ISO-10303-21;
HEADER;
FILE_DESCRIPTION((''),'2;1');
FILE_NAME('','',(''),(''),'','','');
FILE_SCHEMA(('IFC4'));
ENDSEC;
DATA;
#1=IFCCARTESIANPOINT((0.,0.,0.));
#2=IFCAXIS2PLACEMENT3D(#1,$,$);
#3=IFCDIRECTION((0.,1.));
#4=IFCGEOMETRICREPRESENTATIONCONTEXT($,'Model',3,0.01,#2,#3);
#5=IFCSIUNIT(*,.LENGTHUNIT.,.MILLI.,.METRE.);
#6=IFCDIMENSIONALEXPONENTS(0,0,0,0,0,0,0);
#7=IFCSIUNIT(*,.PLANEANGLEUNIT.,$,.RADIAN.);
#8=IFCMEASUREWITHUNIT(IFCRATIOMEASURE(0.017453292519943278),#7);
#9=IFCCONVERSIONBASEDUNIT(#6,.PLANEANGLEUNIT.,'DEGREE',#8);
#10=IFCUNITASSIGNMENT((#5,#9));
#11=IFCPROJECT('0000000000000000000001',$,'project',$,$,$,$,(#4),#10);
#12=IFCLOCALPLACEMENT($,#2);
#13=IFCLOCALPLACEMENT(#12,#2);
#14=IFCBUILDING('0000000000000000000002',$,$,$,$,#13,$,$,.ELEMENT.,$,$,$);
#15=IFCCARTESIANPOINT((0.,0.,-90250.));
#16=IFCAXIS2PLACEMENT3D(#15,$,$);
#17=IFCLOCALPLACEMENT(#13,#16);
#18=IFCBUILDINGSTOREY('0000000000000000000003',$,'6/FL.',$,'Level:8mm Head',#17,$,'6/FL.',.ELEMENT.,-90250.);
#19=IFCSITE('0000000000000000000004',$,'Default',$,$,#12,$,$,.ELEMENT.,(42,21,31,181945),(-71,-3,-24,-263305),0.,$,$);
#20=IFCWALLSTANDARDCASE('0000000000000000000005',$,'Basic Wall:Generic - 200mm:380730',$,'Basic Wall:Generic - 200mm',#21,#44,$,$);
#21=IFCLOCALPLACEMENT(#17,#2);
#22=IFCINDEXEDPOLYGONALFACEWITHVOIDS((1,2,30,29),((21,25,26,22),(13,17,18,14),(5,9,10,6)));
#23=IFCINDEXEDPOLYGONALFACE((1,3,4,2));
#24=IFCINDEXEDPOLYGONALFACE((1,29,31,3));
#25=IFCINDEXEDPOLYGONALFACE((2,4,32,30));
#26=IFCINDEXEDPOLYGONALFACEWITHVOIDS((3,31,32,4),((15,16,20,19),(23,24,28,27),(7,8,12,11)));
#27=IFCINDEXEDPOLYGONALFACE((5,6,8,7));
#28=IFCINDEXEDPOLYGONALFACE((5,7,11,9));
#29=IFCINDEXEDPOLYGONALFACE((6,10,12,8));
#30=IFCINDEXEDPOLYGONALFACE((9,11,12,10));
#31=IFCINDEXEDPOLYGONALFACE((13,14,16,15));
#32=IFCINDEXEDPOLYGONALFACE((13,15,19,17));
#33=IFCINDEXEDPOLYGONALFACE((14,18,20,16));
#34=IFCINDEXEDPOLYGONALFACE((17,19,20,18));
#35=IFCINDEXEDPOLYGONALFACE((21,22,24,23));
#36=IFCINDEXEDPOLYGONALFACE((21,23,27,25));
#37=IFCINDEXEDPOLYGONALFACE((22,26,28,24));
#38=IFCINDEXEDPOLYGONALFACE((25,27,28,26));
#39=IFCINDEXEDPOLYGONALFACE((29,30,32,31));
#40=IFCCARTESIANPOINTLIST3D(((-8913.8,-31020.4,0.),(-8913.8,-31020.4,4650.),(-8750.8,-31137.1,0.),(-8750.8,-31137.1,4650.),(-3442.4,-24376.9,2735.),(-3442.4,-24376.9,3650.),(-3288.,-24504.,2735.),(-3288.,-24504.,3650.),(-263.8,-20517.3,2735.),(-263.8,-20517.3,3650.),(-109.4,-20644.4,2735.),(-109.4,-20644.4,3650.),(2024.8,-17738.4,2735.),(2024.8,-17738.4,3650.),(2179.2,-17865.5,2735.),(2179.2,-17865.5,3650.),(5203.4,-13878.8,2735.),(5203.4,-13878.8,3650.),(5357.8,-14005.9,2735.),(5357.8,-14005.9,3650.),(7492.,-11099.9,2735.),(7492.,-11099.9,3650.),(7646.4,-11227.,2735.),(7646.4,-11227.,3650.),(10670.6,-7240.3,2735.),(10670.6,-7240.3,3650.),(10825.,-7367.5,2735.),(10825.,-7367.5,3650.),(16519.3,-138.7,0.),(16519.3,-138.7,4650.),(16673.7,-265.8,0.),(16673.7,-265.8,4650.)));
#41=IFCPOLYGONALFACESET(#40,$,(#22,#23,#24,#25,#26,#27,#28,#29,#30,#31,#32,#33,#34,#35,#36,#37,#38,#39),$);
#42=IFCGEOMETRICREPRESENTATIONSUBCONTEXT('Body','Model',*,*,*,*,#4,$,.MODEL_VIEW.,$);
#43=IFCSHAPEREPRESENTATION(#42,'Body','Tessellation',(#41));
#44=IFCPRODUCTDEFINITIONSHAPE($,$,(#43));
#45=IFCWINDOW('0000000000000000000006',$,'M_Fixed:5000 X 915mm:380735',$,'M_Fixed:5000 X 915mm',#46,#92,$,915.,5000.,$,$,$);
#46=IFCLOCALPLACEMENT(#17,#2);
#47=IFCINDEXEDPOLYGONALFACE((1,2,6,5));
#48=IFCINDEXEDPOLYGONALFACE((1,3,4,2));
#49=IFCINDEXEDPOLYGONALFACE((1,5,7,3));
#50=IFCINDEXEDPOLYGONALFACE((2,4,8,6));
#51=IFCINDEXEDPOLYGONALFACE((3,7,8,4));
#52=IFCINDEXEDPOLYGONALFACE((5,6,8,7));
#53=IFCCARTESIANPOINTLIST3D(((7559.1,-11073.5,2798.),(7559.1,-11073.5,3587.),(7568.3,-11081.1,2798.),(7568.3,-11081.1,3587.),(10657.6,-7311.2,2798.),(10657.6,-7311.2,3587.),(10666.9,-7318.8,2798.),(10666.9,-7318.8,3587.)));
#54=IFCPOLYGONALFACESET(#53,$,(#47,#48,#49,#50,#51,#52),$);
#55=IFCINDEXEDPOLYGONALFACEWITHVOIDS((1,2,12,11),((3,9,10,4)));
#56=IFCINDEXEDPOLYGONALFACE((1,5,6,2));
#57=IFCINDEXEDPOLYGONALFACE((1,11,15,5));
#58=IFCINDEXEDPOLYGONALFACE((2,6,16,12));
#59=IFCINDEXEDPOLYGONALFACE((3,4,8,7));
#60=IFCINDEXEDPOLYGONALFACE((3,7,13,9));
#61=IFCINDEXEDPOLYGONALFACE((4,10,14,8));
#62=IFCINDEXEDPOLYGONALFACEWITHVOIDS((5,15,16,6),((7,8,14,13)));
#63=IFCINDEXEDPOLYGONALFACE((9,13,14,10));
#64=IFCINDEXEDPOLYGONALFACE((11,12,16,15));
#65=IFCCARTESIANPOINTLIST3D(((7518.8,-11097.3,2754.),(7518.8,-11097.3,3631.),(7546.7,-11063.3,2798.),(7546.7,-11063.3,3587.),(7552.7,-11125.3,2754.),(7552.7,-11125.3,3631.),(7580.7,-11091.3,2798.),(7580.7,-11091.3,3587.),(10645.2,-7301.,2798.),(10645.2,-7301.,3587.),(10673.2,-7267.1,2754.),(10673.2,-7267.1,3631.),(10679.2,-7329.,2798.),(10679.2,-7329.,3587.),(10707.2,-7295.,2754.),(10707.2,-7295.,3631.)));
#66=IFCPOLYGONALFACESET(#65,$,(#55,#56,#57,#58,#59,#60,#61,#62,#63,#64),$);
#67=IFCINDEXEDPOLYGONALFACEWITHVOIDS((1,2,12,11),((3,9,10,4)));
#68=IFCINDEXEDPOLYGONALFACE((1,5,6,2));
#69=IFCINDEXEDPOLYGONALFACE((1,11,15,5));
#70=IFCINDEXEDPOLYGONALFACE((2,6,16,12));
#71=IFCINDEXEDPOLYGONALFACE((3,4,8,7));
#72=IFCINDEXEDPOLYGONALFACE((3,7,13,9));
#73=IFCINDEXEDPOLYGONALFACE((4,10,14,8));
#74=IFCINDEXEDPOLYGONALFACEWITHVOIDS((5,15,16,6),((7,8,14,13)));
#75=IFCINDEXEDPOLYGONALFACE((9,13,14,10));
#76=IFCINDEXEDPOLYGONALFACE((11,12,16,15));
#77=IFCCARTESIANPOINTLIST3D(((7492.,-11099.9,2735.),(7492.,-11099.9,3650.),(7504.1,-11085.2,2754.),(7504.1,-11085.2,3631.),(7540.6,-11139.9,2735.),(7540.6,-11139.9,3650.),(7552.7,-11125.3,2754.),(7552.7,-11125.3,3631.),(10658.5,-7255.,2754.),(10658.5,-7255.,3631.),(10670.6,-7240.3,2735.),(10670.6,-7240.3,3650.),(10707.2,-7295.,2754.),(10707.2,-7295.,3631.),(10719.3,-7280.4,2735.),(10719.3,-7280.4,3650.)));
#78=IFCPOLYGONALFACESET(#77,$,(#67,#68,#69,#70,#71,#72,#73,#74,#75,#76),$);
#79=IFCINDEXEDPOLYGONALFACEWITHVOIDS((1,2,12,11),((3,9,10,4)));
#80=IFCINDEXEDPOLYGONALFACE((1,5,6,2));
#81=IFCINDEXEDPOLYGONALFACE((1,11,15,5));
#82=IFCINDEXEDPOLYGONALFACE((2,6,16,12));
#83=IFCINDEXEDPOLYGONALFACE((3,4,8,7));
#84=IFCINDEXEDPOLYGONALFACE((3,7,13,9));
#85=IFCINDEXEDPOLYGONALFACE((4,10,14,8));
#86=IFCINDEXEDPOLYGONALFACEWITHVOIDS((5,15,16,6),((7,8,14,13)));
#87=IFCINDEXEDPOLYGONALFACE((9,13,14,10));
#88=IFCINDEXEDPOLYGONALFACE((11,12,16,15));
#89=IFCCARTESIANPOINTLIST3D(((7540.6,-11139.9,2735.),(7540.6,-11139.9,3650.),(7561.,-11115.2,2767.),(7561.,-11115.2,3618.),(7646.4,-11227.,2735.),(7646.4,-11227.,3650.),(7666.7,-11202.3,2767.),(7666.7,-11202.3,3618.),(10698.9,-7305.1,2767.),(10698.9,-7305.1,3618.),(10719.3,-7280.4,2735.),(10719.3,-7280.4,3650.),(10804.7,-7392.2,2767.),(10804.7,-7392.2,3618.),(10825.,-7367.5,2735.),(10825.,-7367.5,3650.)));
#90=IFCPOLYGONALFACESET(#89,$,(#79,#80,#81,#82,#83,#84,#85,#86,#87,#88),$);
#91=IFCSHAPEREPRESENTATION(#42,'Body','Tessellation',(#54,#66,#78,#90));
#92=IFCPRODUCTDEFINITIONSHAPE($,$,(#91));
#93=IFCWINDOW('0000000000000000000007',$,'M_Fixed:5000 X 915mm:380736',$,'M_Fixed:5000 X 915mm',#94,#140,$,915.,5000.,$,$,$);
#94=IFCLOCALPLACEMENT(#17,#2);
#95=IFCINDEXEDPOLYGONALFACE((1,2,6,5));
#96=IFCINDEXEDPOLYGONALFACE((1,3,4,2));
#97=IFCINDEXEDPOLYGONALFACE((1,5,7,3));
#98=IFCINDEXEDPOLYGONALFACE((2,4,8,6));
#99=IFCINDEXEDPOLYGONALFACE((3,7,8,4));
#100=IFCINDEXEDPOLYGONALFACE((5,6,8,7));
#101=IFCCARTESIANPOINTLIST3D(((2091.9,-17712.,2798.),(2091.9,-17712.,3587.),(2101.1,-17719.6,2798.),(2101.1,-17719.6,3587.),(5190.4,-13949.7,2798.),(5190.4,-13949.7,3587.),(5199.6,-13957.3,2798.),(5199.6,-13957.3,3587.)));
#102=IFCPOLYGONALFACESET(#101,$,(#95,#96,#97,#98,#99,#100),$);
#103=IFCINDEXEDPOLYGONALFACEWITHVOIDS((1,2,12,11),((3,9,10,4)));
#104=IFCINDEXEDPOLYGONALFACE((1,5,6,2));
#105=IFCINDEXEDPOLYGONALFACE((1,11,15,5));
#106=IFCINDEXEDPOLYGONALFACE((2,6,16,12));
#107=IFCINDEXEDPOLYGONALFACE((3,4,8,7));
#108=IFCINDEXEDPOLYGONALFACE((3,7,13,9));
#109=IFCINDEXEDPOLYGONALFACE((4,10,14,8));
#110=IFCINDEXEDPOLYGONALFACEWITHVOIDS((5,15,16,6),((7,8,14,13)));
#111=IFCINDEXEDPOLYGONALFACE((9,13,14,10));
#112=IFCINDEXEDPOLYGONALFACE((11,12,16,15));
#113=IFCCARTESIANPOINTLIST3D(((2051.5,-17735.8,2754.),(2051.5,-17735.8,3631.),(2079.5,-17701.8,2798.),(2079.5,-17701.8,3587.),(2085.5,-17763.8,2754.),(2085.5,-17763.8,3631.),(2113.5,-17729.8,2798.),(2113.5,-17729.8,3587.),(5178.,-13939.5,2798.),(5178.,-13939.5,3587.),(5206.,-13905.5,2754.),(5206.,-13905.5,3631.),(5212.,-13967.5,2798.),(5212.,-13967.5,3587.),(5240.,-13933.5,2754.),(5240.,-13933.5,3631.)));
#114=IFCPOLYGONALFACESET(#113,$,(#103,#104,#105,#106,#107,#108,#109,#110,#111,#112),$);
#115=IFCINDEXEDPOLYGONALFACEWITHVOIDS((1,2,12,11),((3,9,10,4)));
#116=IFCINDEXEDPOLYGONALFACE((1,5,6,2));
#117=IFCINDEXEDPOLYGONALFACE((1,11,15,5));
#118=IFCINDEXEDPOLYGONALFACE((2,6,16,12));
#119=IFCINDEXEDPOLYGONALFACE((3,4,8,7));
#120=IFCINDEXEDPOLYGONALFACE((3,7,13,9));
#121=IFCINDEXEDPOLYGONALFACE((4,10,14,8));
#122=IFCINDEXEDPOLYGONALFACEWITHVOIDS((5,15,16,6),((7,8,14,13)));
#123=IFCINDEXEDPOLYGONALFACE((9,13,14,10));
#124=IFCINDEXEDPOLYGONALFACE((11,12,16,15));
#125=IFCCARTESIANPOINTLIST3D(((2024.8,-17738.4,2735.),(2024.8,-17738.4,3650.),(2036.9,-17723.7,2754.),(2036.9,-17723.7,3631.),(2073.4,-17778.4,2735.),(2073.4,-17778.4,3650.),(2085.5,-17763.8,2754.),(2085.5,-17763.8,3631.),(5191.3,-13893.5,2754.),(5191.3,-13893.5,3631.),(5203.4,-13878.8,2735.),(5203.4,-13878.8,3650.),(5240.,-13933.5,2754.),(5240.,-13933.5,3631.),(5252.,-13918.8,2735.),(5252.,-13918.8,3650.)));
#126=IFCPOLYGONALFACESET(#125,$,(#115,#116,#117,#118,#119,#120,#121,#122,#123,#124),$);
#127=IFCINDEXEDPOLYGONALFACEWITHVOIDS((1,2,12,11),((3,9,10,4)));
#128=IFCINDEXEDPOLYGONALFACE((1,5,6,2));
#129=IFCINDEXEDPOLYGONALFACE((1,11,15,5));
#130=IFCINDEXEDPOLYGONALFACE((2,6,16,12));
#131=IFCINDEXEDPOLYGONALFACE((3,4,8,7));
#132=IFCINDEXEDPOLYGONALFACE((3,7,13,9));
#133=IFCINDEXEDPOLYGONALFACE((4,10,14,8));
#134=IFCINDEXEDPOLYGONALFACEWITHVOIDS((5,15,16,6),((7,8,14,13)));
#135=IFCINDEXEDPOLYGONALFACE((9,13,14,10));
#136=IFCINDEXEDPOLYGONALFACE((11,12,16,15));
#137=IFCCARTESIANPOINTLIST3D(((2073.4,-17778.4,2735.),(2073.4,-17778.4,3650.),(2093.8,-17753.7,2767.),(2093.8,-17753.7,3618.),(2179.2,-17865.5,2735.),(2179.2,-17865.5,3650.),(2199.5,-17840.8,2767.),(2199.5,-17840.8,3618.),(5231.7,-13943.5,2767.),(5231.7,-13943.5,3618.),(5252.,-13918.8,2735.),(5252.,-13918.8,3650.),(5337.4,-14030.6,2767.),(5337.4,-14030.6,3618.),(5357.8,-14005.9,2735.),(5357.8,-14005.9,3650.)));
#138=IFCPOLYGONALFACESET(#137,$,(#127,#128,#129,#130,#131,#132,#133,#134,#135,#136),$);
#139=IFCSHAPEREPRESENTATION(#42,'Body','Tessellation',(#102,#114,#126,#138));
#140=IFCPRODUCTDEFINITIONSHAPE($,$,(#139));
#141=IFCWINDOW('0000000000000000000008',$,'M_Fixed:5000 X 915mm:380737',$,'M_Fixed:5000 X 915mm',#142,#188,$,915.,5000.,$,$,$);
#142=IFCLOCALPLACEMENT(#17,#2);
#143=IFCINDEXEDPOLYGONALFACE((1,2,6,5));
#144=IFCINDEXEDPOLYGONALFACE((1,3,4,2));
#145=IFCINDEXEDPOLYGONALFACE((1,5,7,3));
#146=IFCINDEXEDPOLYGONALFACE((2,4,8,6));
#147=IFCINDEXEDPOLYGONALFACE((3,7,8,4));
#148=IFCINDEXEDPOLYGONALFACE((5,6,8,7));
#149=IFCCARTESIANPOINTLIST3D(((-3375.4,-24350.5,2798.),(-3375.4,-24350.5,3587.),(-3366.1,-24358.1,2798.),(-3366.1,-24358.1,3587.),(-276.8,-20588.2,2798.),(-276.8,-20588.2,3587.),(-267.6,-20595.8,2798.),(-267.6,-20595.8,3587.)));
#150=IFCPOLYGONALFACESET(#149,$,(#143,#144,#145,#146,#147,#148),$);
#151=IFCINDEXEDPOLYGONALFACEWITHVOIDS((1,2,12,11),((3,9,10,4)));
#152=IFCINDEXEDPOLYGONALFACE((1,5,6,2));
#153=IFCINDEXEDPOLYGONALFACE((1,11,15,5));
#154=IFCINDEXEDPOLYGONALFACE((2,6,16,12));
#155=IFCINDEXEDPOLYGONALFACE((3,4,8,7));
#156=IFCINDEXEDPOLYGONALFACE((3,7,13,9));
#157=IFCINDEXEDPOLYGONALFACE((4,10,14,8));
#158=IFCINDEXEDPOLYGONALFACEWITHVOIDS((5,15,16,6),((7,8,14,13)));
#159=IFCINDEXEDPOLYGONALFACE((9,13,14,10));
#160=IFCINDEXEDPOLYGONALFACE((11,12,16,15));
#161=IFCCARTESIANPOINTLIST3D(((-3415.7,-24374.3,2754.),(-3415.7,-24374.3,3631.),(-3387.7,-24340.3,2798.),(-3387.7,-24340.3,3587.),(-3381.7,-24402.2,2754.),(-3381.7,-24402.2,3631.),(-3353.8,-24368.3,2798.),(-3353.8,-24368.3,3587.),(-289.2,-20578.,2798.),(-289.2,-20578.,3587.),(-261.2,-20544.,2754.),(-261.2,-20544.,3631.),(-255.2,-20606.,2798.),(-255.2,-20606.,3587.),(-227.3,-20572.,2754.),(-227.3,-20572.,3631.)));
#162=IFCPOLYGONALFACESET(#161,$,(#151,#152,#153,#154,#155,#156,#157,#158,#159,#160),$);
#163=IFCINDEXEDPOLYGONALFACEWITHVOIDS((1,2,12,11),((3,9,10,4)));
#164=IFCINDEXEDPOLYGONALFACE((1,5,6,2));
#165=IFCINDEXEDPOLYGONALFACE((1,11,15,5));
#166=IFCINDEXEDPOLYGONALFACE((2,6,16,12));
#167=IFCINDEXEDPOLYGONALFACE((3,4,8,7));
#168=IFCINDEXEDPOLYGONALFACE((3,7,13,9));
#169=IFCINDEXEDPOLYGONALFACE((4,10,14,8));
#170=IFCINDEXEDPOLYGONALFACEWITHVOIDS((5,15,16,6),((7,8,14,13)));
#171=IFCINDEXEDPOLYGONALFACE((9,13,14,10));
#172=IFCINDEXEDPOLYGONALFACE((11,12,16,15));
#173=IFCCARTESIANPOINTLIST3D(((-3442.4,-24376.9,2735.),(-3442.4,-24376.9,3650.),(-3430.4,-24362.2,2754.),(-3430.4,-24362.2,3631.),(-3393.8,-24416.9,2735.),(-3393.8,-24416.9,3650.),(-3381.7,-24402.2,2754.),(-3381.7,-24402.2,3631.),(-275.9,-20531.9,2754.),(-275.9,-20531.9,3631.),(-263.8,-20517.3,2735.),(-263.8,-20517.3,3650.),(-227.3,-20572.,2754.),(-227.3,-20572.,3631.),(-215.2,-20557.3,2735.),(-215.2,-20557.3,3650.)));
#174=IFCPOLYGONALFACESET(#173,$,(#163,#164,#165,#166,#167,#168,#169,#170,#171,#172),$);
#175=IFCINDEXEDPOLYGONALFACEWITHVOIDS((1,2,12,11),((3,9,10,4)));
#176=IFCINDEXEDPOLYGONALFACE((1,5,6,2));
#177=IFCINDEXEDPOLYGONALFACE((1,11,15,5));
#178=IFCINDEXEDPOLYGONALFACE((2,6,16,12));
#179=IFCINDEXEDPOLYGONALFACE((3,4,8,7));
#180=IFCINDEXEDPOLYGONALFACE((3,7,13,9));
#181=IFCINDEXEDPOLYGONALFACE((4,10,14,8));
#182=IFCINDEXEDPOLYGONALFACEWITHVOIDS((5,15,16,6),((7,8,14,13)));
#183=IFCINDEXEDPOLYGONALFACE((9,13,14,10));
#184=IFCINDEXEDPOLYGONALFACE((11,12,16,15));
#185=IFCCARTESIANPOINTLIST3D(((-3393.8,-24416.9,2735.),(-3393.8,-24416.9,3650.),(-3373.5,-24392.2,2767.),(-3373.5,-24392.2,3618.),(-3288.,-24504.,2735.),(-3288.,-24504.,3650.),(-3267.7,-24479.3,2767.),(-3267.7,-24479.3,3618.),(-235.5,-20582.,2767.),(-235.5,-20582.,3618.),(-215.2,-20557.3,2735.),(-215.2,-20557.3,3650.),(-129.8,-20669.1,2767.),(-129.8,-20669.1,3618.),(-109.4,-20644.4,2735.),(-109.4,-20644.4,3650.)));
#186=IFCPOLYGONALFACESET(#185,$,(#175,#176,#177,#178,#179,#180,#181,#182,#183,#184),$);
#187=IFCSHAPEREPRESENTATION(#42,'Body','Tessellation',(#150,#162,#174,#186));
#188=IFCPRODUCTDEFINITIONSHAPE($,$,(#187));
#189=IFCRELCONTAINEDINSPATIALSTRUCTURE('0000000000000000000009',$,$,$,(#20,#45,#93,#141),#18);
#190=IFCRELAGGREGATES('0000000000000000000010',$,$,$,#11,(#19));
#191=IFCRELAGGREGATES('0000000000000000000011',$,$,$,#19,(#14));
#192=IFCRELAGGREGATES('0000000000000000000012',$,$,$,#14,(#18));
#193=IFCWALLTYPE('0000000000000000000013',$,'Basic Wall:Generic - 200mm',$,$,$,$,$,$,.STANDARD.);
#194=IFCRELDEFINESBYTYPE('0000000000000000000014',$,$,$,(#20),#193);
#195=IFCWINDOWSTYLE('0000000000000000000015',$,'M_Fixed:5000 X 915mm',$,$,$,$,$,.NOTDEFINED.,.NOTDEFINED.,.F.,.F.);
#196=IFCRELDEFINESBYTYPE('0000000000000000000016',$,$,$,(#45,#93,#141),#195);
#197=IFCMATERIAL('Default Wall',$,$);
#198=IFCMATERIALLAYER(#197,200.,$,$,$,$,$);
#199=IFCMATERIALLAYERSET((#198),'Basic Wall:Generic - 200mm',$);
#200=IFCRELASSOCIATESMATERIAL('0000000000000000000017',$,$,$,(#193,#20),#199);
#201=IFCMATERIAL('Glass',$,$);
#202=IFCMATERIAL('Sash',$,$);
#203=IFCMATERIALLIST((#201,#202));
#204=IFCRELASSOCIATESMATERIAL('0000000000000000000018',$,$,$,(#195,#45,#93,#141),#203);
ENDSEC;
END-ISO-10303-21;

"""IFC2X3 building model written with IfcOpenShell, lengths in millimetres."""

from ifc_helpers import new_model, entity, si_unit, converted_unit, direction, frame, frame_2d, origin, place, context, subcontext, project, spatial, polyline, rectangle, outline, extrude, source, transform, mapped, material, material_list, layer, layer_set, layer_usage, type_object, type_shapes, element, fill, save


model = new_model("IFC2X3")

# Units and contexts
model_context = context("Model", 3, precision=0.01, world=origin(), true_north=direction((0.0, 1.0)))
body_context = subcontext(model_context, "Body", "Model", "MODEL_VIEW")
ifc_project = project(units=[si_unit("LENGTHUNIT", "METRE", prefix="MILLI"), converted_unit("PLANEANGLEUNIT", "DEGREE", entity("IfcRatioMeasure", 0.017453292519943278), si_unit("PLANEANGLEUNIT", "RADIAN"), dimensions=[0, 0, 0, 0, 0, 0, 0])], contexts=[model_context])

# Site, building, storey
site_placement = place(None, origin())
site = spatial("IfcSite", under=ifc_project, at=site_placement, Name="Default", CompositionType="ELEMENT", RefLatitude=(42, 21, 31, 181945), RefLongitude=(-71, -3, -24, -263305), RefElevation=0.0)
building_placement = place(site_placement, origin())
building = spatial("IfcBuilding", under=site, at=building_placement, CompositionType="ELEMENT")
storey_placement = place(building_placement, frame((0.0, 0.0, -90250.0)))
storey = spatial("IfcBuildingStorey", under=building, at=storey_placement, Name="6/FL.", ObjectType="Level:8mm Head", LongName="6/FL.", CompositionType="ELEMENT", Elevation=-90250.0)

# Shared definitions
ifc_material_1 = material(Name="Default Wall")
ifc_layer = layer(ifc_material_1, 200.0)
ifc_layer_set = layer_set([ifc_layer], Name="Basic Wall:Generic - 200mm")
ifc_layer_usage = layer_usage(ifc_layer_set, "AXIS2", "NEGATIVE", 100.0)
wall_type = type_object("IfcWallType", Name="Basic Wall:Generic - 200mm", PredefinedType="STANDARD", material=ifc_layer_set)

# Wall, openings, windows
wall_1_placement = place(storey_placement, frame((17105.1, 415.3, 0.0), z_axis=(0.0, 0.0, 1.0), x_axis=(-0.635723, -0.771917, 0.0)))
wall_1 = element("IfcWallStandardCase", 1, at=wall_1_placement, inside=storey, type_object=wall_type, material=ifc_layer_usage, Name="Basic Wall:Generic - 200mm:380730", ObjectType="Basic Wall:Generic - 200mm", context=body_context, shape_type="SweptSolid", body=[
    extrude(outline(polyline([(40806.5, -100.0), (40793.0, 100.0), (37219.3, 100.0), (37019.3, 100.0), (800.0, 100.0), (800.0, -100.0), (37019.3, -100.0), (37219.3, -100.0), (40806.5, -100.0)])), origin(), (0.0, 0.0, 1.0), 4650.0),
])
opening_1_placement = place(wall_1_placement, origin())
element("IfcOpeningElement", 2, at=opening_1_placement, cuts=wall_1, ObjectType="Opening", context=body_context, shape_type="SweptSolid", body=[
    extrude(rectangle(XDim=1000.0, YDim=1012.7, at=frame_2d((0.0, 0.0), x_axis=(1.0, 0.0))), frame((293.7, -183.3, 500.0), z_axis=(0.0, 1.0, 0.0), x_axis=(0.0, 0.0, -1.0)), (0.0, 0.0, 1.0), 1010.1),
])
opening_2_placement = place(wall_1_placement, frame((15000.0, 100.0, 2735.0)))
opening_2 = element("IfcOpeningElement", 3, at=opening_2_placement, cuts=wall_1, ObjectType="Opening", context=body_context, shape_type="SweptSolid", body=[
    extrude(rectangle(XDim=915.0, YDim=5000.0, at=frame_2d((457.5, 2500.0), x_axis=(1.0, 0.0))), frame((0.0, 0.0, 0.0), z_axis=(0.0, -1.0, 0.0), x_axis=(0.0, 0.0, 1.0)), (0.0, 0.0, 1.0), 200.0),
])
opening_3_placement = place(wall_1_placement, frame((23600.0, 100.0, 2735.0)))
opening_3 = element("IfcOpeningElement", 4, at=opening_3_placement, cuts=wall_1, ObjectType="Opening", context=body_context, shape_type="SweptSolid", body=[
    extrude(rectangle(XDim=915.0, YDim=5000.0, at=frame_2d((457.5, 2500.0), x_axis=(1.0, 0.0))), frame((0.0, 0.0, 0.0), z_axis=(0.0, -1.0, 0.0), x_axis=(0.0, 0.0, 1.0)), (0.0, 0.0, 1.0), 200.0),
])
opening_4_placement = place(wall_1_placement, frame((32200.0, 100.0, 2735.0)))
opening_4 = element("IfcOpeningElement", 5, at=opening_4_placement, cuts=wall_1, ObjectType="Opening", context=body_context, shape_type="SweptSolid", body=[
    extrude(rectangle(XDim=915.0, YDim=5000.0, at=frame_2d((457.5, 2500.0), x_axis=(1.0, 0.0))), frame((0.0, 0.0, 0.0), z_axis=(0.0, -1.0, 0.0), x_axis=(0.0, 0.0, 1.0)), (0.0, 0.0, 1.0), 200.0),
])
ifc_material_2 = material(Name="Glass")
ifc_material_3 = material(Name="Sash")
ifc_material_list = material_list([ifc_material_2, ifc_material_3])
window_style_1 = type_object("IfcWindowStyle", Name="M_Fixed:5000 X 915mm", ConstructionType="NOTDEFINED", OperationType="NOTDEFINED", ParameterTakesPrecedence=False, Sizeable=False, material=ifc_material_list)
shared_shape_1 = source(origin(), body_context, "Body", "SweptSolid", [
    extrude(rectangle(XDim=12.0, YDim=4874.0, at=frame_2d((0.0, 0.0), x_axis=(1.0, 0.0))), frame((2500.0, 159.0, 63.0), z_axis=(0.0, 0.0, 1.0), x_axis=(0.0, -1.0, 0.0)), (0.0, 0.0, 1.0), 789.0),
    extrude(outline(polyline([(-2481.0, -438.5), (2481.0, -438.5), (2481.0, 438.5), (-2481.0, 438.5), (-2481.0, -438.5)]), holes=[polyline([(-2437.0, -394.5), (-2437.0, 394.5), (2437.0, 394.5), (2437.0, -394.5), (-2437.0, -394.5)])]), frame((2500.0, 137.0, 457.5), z_axis=(0.0, 1.0, 0.0), x_axis=(1.0, 0.0, 0.0)), (0.0, 0.0, 1.0), 44.0),
    extrude(outline(polyline([(-2500.0, -457.5), (2500.0, -457.5), (2500.0, 457.5), (-2500.0, 457.5), (-2500.0, -457.5)]), holes=[polyline([(-2481.0, -438.5), (-2481.0, 438.5), (2481.0, 438.5), (2481.0, -438.5), (-2481.0, -438.5)])]), frame((2500.0, 137.0, 457.5), z_axis=(0.0, 1.0, 0.0), x_axis=(1.0, 0.0, 0.0)), (0.0, 0.0, 1.0), 63.0),
    extrude(outline(polyline([(-2500.0, -457.5), (2500.0, -457.5), (2500.0, 457.5), (-2500.0, 457.5), (-2500.0, -457.5)]), holes=[polyline([(-2468.0, -425.5), (-2468.0, 425.5), (2468.0, 425.5), (2468.0, -425.5), (-2468.0, -425.5)])]), frame((2500.0, 0.0, 457.5), z_axis=(0.0, 1.0, 0.0), x_axis=(1.0, 0.0, 0.0)), (0.0, 0.0, 1.0), 137.0),
])
type_shapes(window_style_1, [shared_shape_1])
window_1_placement = place(opening_2_placement, frame((0.0, 0.0, 0.0), z_axis=(0.0, 0.0, 1.0), x_axis=(-1.0, 0.0, 0.0)))
window_1 = element("IfcWindow", 6, at=window_1_placement, inside=storey, type_object=window_style_1, material=ifc_material_list, Name="M_Fixed:5000 X 915mm:380735", ObjectType="M_Fixed:5000 X 915mm", OverallHeight=915.0, OverallWidth=5000.0, context=body_context, shape_type="MappedRepresentation", body=[
    mapped(shared_shape_1, transform((0.0, 0.0, 0.0), scale=1.0)),
])
fill(opening_2, window_1)
window_2_placement = place(opening_3_placement, frame((0.0, 0.0, 0.0), z_axis=(0.0, 0.0, 1.0), x_axis=(-1.0, 0.0, 0.0)))
window_2 = element("IfcWindow", 7, at=window_2_placement, inside=storey, type_object=window_style_1, material=ifc_material_list, Name="M_Fixed:5000 X 915mm:380736", ObjectType="M_Fixed:5000 X 915mm", OverallHeight=915.0, OverallWidth=5000.0, context=body_context, shape_type="MappedRepresentation", body=[
    mapped(shared_shape_1, transform((0.0, 0.0, 0.0), scale=1.0)),
])
fill(opening_3, window_2)
window_3_placement = place(opening_4_placement, frame((0.0, 0.0, 0.0), z_axis=(0.0, 0.0, 1.0), x_axis=(-1.0, 0.0, 0.0)))
window_3 = element("IfcWindow", 8, at=window_3_placement, inside=storey, type_object=window_style_1, material=ifc_material_list, Name="M_Fixed:5000 X 915mm:380737", ObjectType="M_Fixed:5000 X 915mm", OverallHeight=915.0, OverallWidth=5000.0, context=body_context, shape_type="MappedRepresentation", body=[
    mapped(shared_shape_1, transform((0.0, 0.0, 0.0), scale=1.0)),
])
fill(opening_4, window_3)

save(model, "model.ifc")
